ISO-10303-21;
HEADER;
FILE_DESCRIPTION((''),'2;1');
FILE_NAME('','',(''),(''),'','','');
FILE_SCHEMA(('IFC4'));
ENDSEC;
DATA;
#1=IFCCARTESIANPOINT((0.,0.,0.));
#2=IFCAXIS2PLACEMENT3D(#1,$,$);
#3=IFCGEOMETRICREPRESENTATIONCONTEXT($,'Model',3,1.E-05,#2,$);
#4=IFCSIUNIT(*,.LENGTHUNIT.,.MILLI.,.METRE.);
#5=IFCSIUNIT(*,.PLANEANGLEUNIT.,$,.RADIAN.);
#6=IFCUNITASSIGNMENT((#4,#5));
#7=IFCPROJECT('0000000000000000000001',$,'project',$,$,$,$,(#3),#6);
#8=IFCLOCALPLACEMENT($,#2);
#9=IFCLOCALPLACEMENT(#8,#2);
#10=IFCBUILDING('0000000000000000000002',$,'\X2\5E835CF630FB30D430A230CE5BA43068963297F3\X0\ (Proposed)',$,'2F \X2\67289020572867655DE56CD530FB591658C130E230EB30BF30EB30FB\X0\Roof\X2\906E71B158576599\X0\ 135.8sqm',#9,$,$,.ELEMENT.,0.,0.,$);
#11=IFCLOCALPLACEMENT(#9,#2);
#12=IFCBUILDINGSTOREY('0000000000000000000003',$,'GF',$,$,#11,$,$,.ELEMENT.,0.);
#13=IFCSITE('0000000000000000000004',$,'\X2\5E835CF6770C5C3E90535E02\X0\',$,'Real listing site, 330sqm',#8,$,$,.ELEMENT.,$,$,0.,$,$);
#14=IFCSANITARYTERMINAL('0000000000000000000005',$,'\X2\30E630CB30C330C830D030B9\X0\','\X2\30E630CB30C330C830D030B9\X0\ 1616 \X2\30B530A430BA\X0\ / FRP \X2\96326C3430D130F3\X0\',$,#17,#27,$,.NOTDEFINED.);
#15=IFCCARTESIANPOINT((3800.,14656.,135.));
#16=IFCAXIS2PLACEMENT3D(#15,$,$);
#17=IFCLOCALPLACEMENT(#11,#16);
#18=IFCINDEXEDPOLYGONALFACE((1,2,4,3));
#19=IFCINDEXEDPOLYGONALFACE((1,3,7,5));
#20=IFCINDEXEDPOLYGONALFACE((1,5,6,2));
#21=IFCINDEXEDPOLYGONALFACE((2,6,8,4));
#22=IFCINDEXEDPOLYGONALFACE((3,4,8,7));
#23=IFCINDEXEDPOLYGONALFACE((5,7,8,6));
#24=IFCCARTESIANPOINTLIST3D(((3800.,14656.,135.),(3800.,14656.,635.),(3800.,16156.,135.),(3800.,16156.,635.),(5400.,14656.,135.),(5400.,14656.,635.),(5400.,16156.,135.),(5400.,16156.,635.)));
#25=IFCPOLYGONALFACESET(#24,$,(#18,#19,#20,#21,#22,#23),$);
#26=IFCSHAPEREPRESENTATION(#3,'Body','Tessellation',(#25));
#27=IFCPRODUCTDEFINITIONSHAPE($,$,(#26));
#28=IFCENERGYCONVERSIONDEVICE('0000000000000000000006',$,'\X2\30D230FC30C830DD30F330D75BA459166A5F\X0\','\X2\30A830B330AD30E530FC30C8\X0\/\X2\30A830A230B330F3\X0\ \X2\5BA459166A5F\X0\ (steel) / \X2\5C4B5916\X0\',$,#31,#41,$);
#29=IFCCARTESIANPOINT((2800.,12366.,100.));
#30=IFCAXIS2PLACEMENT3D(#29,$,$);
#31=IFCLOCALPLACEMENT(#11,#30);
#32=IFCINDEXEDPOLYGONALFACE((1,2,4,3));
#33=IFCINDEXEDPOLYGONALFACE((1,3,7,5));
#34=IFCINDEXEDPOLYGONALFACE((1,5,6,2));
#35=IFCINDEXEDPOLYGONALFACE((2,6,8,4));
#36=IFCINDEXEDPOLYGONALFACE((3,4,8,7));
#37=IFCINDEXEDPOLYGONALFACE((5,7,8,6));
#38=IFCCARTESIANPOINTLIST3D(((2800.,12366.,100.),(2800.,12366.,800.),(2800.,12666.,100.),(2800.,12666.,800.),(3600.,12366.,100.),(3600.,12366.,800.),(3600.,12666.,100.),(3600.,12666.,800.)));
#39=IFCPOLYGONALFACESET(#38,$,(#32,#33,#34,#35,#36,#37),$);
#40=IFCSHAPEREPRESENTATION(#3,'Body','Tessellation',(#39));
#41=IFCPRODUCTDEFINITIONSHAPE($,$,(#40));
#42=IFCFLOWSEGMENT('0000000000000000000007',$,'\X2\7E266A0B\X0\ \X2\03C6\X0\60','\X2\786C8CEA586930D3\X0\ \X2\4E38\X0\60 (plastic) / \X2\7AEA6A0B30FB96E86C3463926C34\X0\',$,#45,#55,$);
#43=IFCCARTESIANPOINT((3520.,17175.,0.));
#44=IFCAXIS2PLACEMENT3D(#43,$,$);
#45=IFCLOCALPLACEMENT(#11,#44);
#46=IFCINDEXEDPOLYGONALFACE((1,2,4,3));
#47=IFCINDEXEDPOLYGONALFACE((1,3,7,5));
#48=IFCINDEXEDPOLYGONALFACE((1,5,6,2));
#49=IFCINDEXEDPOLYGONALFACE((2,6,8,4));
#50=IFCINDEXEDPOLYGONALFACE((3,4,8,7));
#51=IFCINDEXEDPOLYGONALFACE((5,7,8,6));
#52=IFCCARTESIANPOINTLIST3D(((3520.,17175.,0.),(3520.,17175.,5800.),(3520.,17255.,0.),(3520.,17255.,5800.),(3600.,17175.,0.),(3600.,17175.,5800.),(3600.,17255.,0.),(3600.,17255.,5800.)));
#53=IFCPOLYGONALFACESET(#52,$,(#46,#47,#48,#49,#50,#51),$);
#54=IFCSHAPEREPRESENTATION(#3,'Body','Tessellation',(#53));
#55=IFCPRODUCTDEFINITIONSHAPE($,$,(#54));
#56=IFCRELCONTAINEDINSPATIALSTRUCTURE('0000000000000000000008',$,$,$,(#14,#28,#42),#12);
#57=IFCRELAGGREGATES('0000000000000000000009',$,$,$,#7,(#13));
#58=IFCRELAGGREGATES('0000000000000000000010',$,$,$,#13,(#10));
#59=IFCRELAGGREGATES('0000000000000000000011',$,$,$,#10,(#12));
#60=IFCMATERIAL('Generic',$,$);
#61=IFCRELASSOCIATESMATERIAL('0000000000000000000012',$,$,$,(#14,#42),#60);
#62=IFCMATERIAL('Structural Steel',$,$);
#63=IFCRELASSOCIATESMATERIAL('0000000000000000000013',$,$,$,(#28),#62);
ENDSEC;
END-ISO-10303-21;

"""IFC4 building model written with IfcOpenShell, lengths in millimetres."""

from ifc_helpers import new_model, si_unit, frame, frame_2d, origin, place, context, project, spatial, rectangle, extrude, material, element, save


model = new_model("IFC4")

# Units and contexts
model_context = context("Model", 3, precision=1e-05, world=origin())
ifc_project = project(units=[si_unit("LENGTHUNIT", "METRE", prefix="MILLI"), si_unit("PLANEANGLEUNIT", "RADIAN")], contexts=[model_context])

# Site, building, storey
site_placement = place(None, origin())
site = spatial("IfcSite", under=ifc_project, at=site_placement, Name="広島県尾道市", ObjectType="Real listing site, 330sqm", CompositionType="ELEMENT", RefElevation=0.0)
building_placement = place(site_placement, origin())
building = spatial("IfcBuilding", under=site, at=building_placement, Name="広島・ピアノ室と防音 (Proposed)", ObjectType="2F 木造在来工法・外壁モルタル・Roof遮熱塗料 135.8sqm", CompositionType="ELEMENT", ElevationOfRefHeight=0.0, ElevationOfTerrain=0.0)
storey_placement = place(building_placement, origin())
storey = spatial("IfcBuildingStorey", under=building, at=storey_placement, Name="GF", CompositionType="ELEMENT", Elevation=0.0)

# Shared definitions
ifc_material_1 = material(Name="Generic")

# Sanitary terminal
sanitary_terminal_placement = place(storey_placement, frame((3800.0, 14656.0, 135.0)))
element("IfcSanitaryTerminal", 1, at=sanitary_terminal_placement, inside=storey, material=ifc_material_1, Name="ユニットバス", Description="ユニットバス 1616 サイズ / FRP 防水パン", PredefinedType="NOTDEFINED", context=model_context, shape_type="SweptSolid", body=[
    extrude(rectangle(XDim=1600.0, YDim=1500.0, at=frame_2d((800.0, 750.0))), frame((3800.0, 14656.0, 135.0)), (0.0, 0.0, 1.0), 500.0),
])

# Energy conversion device
ifc_material_2 = material(Name="Structural Steel")
energy_conversion_device_placement = place(storey_placement, frame((2800.0, 12366.0, 100.0)))
element("IfcEnergyConversionDevice", 2, at=energy_conversion_device_placement, inside=storey, material=ifc_material_2, Name="ヒートポンプ室外機", Description="エコキュート/エアコン 室外機 (steel) / 屋外", context=model_context, shape_type="SweptSolid", body=[
    extrude(rectangle(XDim=800.0, YDim=300.0, at=frame_2d((400.0, 150.0))), frame((2800.0, 12366.0, 100.0)), (0.0, 0.0, 1.0), 700.0),
])

# Flow segment
flow_segment_placement = place(storey_placement, frame((3520.0, 17175.0, 0.0)))
element("IfcFlowSegment", 3, at=flow_segment_placement, inside=storey, material=ifc_material_1, Name="縦樋 φ60", Description="硬質塩ビ 丸60 (plastic) / 竪樋・雨水排水", context=model_context, shape_type="SweptSolid", body=[
    extrude(rectangle(XDim=80.0, YDim=80.0, at=frame_2d((40.0, 40.0))), frame((3520.0, 17175.0, 0.0)), (0.0, 0.0, 1.0), 5800.0),
])

save(model, "model.ifc")
